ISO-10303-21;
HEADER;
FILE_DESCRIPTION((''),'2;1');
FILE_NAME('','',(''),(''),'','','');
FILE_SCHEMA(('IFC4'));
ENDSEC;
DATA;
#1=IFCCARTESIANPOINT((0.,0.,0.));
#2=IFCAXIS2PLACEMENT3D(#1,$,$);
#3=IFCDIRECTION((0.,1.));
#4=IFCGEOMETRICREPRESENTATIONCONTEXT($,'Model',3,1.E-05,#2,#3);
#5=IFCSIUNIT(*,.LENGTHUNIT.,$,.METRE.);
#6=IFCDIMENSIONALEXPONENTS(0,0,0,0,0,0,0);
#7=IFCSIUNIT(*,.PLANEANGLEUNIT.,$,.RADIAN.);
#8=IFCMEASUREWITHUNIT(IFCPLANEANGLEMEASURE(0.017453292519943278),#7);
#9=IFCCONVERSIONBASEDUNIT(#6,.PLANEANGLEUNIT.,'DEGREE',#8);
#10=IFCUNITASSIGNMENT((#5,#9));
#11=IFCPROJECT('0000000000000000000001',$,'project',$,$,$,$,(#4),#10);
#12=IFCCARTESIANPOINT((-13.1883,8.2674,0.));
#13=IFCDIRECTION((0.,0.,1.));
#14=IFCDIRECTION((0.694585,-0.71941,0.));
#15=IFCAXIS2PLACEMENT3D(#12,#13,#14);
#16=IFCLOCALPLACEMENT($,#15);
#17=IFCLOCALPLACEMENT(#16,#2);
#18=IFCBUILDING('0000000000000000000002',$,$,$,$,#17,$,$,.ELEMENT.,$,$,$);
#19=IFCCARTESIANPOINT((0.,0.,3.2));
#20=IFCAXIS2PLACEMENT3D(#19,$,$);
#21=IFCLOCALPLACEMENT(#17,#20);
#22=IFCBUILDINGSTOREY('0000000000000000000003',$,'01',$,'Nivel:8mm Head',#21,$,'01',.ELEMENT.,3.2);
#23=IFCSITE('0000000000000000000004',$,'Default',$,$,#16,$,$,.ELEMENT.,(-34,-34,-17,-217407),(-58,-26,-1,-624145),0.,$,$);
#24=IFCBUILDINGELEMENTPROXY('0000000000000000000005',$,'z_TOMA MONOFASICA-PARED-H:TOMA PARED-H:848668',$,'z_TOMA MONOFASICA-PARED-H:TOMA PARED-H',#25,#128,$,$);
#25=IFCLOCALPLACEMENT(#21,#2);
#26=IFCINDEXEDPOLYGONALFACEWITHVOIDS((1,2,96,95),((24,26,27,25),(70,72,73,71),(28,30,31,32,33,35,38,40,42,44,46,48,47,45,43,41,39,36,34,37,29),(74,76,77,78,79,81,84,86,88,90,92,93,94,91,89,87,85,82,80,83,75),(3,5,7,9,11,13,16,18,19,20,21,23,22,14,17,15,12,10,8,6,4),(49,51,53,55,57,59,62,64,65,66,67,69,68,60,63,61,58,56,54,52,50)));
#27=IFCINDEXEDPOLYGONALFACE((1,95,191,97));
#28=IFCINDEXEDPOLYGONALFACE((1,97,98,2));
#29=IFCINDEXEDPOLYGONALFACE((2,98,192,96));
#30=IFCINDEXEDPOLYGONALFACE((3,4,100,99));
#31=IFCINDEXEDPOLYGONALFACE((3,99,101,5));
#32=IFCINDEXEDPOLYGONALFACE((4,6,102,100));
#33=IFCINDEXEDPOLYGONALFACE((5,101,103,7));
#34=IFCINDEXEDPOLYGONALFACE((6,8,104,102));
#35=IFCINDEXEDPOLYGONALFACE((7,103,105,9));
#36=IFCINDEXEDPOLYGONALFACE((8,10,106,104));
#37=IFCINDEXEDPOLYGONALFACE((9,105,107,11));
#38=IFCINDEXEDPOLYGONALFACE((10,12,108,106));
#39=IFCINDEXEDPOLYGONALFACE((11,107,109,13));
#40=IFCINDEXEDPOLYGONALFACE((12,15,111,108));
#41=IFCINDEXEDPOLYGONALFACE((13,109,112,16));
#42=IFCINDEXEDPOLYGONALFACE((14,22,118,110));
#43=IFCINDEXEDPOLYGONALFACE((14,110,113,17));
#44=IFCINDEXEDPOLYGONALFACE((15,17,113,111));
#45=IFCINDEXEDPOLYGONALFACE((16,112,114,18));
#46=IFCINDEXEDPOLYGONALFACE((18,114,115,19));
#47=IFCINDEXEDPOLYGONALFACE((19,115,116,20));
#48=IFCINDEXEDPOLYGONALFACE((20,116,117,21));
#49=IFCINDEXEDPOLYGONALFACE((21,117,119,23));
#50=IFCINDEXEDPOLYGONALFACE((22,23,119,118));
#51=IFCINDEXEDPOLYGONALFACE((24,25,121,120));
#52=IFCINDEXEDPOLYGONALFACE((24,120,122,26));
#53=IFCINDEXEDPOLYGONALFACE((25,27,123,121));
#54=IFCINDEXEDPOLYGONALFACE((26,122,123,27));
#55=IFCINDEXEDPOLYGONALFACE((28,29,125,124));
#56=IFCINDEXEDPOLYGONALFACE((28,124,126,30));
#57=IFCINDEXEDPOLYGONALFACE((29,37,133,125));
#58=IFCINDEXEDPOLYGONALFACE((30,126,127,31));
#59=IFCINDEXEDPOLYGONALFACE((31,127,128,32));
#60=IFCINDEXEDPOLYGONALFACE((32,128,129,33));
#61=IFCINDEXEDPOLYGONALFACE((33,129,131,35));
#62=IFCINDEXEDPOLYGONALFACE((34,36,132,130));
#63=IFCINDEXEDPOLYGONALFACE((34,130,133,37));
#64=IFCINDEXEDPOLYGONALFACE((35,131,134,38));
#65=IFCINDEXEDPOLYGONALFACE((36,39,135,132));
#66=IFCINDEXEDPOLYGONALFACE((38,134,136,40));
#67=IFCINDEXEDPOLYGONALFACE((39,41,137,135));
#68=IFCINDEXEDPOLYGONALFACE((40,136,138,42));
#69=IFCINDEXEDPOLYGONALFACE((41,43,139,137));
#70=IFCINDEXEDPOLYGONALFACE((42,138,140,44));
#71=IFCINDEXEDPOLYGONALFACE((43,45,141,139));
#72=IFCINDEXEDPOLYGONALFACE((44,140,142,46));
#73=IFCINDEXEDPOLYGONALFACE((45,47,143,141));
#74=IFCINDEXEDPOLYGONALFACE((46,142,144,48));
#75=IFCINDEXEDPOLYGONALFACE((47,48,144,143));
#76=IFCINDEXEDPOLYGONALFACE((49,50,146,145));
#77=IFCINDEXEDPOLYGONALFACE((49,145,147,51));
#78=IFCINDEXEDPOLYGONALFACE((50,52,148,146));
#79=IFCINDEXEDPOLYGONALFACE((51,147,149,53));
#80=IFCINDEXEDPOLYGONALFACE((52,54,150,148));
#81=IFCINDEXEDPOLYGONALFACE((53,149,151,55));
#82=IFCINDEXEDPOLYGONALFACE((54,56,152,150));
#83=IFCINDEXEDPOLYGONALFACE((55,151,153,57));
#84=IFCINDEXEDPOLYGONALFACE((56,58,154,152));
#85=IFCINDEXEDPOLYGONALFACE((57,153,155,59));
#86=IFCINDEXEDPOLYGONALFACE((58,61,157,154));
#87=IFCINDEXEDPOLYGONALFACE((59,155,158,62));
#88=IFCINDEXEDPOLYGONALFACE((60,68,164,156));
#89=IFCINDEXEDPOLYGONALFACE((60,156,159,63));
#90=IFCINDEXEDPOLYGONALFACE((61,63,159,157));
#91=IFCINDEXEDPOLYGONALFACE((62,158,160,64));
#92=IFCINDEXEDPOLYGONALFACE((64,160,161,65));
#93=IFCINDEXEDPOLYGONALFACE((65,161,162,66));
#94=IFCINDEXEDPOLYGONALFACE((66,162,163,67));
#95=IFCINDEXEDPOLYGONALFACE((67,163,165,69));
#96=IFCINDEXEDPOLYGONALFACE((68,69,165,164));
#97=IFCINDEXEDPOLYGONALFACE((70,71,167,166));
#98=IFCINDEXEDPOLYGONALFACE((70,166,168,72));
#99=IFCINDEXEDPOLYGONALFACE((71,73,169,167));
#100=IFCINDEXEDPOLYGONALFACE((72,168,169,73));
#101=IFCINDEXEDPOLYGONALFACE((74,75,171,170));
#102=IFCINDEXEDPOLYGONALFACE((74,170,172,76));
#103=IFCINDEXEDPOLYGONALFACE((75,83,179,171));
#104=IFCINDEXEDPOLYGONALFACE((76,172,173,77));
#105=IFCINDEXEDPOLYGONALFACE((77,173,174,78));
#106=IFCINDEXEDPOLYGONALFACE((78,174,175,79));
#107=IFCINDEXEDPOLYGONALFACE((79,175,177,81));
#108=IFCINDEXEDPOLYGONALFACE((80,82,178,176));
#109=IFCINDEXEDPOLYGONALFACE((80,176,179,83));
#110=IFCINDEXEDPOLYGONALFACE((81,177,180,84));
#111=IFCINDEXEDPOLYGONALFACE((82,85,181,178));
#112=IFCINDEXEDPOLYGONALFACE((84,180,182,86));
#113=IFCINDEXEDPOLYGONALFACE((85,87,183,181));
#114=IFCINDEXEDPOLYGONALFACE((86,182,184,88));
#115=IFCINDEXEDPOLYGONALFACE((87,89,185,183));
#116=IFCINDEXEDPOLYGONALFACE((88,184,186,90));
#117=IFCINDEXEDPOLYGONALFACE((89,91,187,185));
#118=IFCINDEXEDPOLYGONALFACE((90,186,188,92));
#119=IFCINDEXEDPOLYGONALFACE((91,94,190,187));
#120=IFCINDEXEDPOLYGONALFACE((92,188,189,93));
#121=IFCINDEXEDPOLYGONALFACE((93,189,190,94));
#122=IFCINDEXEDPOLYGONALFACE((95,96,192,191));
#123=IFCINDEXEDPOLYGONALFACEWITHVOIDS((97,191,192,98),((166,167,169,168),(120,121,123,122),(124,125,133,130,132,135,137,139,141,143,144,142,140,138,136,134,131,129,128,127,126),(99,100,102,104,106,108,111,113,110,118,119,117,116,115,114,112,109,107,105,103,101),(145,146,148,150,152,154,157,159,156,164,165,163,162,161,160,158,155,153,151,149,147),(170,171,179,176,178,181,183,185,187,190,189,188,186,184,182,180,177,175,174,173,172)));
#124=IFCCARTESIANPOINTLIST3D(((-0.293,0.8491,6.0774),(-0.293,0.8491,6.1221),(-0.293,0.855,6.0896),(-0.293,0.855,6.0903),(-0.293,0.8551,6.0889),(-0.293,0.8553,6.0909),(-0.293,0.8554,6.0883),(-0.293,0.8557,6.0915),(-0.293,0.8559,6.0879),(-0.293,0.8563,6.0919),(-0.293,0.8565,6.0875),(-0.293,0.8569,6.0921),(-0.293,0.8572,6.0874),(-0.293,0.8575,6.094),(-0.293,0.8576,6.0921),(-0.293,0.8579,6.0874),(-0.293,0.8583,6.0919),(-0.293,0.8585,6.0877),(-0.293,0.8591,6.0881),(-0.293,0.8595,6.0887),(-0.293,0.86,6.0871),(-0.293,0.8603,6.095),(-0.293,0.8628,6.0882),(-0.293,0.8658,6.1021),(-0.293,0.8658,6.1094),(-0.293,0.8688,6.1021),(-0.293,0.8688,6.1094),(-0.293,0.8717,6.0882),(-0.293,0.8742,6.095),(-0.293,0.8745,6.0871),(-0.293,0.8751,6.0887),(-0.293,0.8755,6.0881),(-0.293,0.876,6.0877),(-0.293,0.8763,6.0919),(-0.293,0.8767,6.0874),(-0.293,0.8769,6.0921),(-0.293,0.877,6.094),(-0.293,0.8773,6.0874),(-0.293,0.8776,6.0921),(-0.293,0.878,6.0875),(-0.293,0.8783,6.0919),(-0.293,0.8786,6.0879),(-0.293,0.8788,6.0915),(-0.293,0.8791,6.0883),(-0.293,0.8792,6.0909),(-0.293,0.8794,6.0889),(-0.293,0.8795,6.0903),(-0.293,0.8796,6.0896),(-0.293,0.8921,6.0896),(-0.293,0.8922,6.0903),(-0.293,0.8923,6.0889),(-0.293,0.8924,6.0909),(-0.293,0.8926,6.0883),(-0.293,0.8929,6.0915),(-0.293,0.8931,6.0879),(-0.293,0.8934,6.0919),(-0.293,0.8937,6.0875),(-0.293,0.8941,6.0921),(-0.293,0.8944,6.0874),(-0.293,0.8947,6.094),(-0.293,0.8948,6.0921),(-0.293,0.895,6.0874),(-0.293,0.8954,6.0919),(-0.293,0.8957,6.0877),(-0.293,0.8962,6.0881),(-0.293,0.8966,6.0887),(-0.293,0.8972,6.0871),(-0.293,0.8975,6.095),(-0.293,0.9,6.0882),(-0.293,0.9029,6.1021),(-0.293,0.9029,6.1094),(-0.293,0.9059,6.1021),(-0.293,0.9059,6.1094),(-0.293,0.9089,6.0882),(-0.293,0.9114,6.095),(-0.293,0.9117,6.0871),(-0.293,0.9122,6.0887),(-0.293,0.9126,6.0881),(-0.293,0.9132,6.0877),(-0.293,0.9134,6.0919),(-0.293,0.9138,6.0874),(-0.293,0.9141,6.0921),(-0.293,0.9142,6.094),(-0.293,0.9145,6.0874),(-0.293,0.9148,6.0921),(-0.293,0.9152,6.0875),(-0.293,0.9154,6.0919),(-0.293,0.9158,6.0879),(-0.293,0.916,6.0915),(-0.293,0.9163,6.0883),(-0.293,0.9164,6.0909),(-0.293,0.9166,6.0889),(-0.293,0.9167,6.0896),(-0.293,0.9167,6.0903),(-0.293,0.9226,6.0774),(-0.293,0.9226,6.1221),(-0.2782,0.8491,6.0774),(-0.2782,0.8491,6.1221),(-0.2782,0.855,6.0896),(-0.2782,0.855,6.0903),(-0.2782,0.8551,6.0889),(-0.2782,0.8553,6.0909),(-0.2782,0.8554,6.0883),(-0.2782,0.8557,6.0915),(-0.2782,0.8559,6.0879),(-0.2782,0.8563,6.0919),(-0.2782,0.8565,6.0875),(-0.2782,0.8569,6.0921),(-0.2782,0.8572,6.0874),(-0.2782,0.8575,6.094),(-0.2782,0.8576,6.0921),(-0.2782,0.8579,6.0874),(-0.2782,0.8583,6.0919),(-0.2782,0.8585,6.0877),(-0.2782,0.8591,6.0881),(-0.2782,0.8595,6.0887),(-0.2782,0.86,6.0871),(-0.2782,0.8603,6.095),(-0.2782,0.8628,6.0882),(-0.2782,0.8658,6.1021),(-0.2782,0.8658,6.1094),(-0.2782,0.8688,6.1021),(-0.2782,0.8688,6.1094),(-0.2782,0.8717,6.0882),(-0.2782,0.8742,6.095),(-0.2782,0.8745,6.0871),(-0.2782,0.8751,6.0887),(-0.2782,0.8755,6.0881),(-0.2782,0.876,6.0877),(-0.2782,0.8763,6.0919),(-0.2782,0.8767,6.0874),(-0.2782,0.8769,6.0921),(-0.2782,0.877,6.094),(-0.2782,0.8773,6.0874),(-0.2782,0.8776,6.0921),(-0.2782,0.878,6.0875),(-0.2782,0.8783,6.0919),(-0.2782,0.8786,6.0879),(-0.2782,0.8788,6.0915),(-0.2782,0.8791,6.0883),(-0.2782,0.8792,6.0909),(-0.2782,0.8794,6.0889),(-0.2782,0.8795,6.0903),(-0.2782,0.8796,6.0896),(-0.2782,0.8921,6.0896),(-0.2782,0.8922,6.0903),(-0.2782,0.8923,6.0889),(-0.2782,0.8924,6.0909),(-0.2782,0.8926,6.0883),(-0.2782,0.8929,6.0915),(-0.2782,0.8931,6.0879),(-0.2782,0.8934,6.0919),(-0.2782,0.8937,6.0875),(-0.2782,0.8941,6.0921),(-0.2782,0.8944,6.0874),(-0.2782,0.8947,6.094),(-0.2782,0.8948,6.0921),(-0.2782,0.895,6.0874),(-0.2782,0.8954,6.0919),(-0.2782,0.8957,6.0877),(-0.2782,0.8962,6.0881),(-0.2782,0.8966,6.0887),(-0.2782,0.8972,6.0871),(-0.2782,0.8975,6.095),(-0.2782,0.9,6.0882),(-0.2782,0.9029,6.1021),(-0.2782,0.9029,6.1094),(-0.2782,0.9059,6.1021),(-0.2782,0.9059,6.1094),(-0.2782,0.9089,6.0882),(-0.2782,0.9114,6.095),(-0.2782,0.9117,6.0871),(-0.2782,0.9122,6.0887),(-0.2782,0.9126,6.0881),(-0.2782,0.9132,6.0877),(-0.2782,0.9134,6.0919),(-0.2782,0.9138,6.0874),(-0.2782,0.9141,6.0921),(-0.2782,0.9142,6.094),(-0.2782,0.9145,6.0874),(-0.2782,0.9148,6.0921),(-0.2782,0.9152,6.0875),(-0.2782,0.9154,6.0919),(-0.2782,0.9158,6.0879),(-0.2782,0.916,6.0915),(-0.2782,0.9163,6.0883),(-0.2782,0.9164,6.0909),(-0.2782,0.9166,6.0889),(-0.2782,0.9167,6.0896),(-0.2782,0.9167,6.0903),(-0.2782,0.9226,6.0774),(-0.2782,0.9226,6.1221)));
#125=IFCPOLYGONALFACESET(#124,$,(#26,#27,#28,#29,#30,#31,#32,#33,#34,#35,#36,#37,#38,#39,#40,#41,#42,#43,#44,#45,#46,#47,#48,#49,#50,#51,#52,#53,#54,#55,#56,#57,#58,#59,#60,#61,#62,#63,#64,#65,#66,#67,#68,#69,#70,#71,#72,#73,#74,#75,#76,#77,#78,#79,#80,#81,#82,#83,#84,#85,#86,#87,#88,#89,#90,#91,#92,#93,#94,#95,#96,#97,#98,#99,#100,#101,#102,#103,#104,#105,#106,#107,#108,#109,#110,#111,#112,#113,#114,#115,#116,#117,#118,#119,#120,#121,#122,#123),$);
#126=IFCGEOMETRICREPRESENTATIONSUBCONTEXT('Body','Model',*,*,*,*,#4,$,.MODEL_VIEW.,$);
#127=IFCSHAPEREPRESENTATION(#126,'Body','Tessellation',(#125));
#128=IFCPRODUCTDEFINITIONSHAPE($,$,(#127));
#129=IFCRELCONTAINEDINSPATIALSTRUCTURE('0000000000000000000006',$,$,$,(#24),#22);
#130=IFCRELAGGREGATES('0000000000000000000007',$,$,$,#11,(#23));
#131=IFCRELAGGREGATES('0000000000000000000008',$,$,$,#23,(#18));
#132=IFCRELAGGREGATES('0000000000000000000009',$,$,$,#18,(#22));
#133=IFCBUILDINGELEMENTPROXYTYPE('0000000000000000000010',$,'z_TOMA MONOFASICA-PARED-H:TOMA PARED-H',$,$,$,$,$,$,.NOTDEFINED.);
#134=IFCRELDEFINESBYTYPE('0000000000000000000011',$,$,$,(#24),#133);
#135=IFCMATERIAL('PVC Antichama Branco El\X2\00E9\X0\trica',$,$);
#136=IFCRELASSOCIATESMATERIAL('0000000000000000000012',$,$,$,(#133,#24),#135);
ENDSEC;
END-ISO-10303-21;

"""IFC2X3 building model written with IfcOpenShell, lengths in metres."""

from ifc_helpers import new_model, entity, si_unit, converted_unit, direction, frame, frame_2d, origin, place, context, subcontext, project, spatial, polyline, circle_curve, parameter, trimmed, segment, composite_curve, outline, extrude, source, transform, mapped, material, type_object, type_shapes, element, save


model = new_model("IFC2X3")

# Units and contexts
model_context = context("Model", 3, precision=1e-05, world=origin(), true_north=direction((0.0, 1.0)))
body_context = subcontext(model_context, "Body", "Model", "MODEL_VIEW")
ifc_project = project(units=[si_unit("LENGTHUNIT", "METRE"), converted_unit("PLANEANGLEUNIT", "DEGREE", entity("IfcPlaneAngleMeasure", 0.017453292519943278), si_unit("PLANEANGLEUNIT", "RADIAN"), dimensions=[0, 0, 0, 0, 0, 0, 0])], contexts=[model_context])

# Site, building, storey
site_placement = place(None, frame((-13.1883, 8.2674, 0.0), z_axis=(0.0, 0.0, 1.0), x_axis=(0.694585, -0.71941, 0.0)))
site = spatial("IfcSite", under=ifc_project, at=site_placement, Name="Default", CompositionType="ELEMENT", RefLatitude=(-34, -34, -17, -217407), RefLongitude=(-58, -26, -1, -624145), RefElevation=0.0)
building_placement = place(site_placement, origin())
building = spatial("IfcBuilding", under=site, at=building_placement, CompositionType="ELEMENT")
storey_placement = place(building_placement, frame((0.0, 0.0, 3.2)))
storey = spatial("IfcBuildingStorey", under=building, at=storey_placement, Name="01", ObjectType="Nivel:8mm Head", LongName="01", CompositionType="ELEMENT", Elevation=3.2)

# Building element proxy
ifc_material_1 = material(Name="PVC Antichama Branco Elétrica")
building_element_proxy_type_1 = type_object("IfcBuildingElementProxyType", Name="z_TOMA MONOFASICA-PARED-H:TOMA PARED-H", PredefinedType="NOTDEFINED", material=ifc_material_1)
shared_shape_1 = source(origin(), body_context, "Body", "SweptSolid", [
    extrude(outline(polyline([(-0.0368, -0.0223), (0.0368, -0.0223), (0.0368, 0.0223), (-0.0368, 0.0223), (-0.0368, -0.0223)]), holes=[composite_curve([segment(polyline([(0.0141, 0.0115), (0.0116, 0.0047)]), True, "CONTINUOUS"), segment(polyline([(0.0116, 0.0047), (0.0088, 0.0057)]), True, "CONTINUOUS"), segment(polyline([(0.0088, 0.0057), (0.0096, 0.0078)]), True, "CONTINUOUS"), segment(trimmed(circle_curve(frame_2d((0.0087, 0.0099), x_axis=(1.0, 0.0)), 0.0024), [parameter(27.118901)], [parameter(292.881099)], True, "PARAMETER"), False, "CONTINUOUS"), segment(polyline([(0.0108, 0.011), (0.0113, 0.0126)]), True, "CONTINUOUS"), segment(polyline([(0.0113, 0.0126), (0.0141, 0.0115)]), True, "CONTINUOUS")], self_intersect=False), composite_curve([segment(polyline([(0.0255, 0.0047), (0.023, 0.0115)]), True, "CONTINUOUS"), segment(polyline([(0.023, 0.0115), (0.0258, 0.0126)]), True, "CONTINUOUS"), segment(polyline([(0.0258, 0.0126), (0.0264, 0.011)]), True, "CONTINUOUS"), segment(trimmed(circle_curve(frame_2d((0.0285, 0.0099), x_axis=(1.0, 0.0)), 0.0024), [parameter(247.118901)], [parameter(152.881099)], True, "PARAMETER"), False, "CONTINUOUS"), segment(polyline([(0.0276, 0.0078), (0.0283, 0.0057)]), True, "CONTINUOUS"), segment(polyline([(0.0283, 0.0057), (0.0255, 0.0047)]), True, "CONTINUOUS")], self_intersect=False), polyline([(0.0201, -0.0024), (0.0201, -0.0097), (0.0171, -0.0097), (0.0171, -0.0024), (0.0201, -0.0024)]), composite_curve([segment(polyline([(-0.0141, 0.0115), (-0.0113, 0.0126)]), True, "CONTINUOUS"), segment(polyline([(-0.0113, 0.0126), (-0.0108, 0.011)]), True, "CONTINUOUS"), segment(trimmed(circle_curve(frame_2d((-0.0087, 0.0099), x_axis=(1.0, 0.0)), 0.0024), [parameter(247.118901)], [parameter(152.881099)], True, "PARAMETER"), False, "CONTINUOUS"), segment(polyline([(-0.0096, 0.0078), (-0.0088, 0.0057)]), True, "CONTINUOUS"), segment(polyline([(-0.0088, 0.0057), (-0.0116, 0.0047)]), True, "CONTINUOUS"), segment(polyline([(-0.0116, 0.0047), (-0.0141, 0.0115)]), True, "CONTINUOUS")], self_intersect=False), composite_curve([segment(polyline([(-0.0255, 0.0047), (-0.0283, 0.0057)]), True, "CONTINUOUS"), segment(polyline([(-0.0283, 0.0057), (-0.0276, 0.0078)]), True, "CONTINUOUS"), segment(trimmed(circle_curve(frame_2d((-0.0285, 0.0099), x_axis=(1.0, 0.0)), 0.0024), [parameter(27.118901)], [parameter(292.881099)], True, "PARAMETER"), False, "CONTINUOUS"), segment(polyline([(-0.0264, 0.011), (-0.0258, 0.0126)]), True, "CONTINUOUS"), segment(polyline([(-0.0258, 0.0126), (-0.023, 0.0115)]), True, "CONTINUOUS"), segment(polyline([(-0.023, 0.0115), (-0.0255, 0.0047)]), True, "CONTINUOUS")], self_intersect=False), polyline([(-0.0201, -0.0024), (-0.0171, -0.0024), (-0.0171, -0.0097), (-0.0201, -0.0097), (-0.0201, -0.0024)])]), frame((0.0, -0.005, 0.0223), z_axis=(0.0, 1.0, 0.0), x_axis=(1.0, 0.0, 0.0)), (0.0, 0.0, 1.0), 0.0148),
])
type_shapes(building_element_proxy_type_1, [shared_shape_1])
for number, where, z_axis, x_axis, name in (
    (1, (-0.288, 0.8858, 6.0774), (0.0, 0.0, 1.0), (0.0, -1.0, 0.0), "z_TOMA MONOFASICA-PARED-H:TOMA PARED-H:848668"),
):
    element("IfcBuildingElementProxy", number, at=place(storey_placement, frame(where, z_axis=z_axis, x_axis=x_axis)), inside=storey, type_object=building_element_proxy_type_1, material=ifc_material_1, Name=name, ObjectType="z_TOMA MONOFASICA-PARED-H:TOMA PARED-H", context=body_context, shape_type="MappedRepresentation", body=[
        mapped(shared_shape_1, transform((0.0, 0.0, 0.0), scale=1.0)),
    ])

save(model, "model.ifc")
